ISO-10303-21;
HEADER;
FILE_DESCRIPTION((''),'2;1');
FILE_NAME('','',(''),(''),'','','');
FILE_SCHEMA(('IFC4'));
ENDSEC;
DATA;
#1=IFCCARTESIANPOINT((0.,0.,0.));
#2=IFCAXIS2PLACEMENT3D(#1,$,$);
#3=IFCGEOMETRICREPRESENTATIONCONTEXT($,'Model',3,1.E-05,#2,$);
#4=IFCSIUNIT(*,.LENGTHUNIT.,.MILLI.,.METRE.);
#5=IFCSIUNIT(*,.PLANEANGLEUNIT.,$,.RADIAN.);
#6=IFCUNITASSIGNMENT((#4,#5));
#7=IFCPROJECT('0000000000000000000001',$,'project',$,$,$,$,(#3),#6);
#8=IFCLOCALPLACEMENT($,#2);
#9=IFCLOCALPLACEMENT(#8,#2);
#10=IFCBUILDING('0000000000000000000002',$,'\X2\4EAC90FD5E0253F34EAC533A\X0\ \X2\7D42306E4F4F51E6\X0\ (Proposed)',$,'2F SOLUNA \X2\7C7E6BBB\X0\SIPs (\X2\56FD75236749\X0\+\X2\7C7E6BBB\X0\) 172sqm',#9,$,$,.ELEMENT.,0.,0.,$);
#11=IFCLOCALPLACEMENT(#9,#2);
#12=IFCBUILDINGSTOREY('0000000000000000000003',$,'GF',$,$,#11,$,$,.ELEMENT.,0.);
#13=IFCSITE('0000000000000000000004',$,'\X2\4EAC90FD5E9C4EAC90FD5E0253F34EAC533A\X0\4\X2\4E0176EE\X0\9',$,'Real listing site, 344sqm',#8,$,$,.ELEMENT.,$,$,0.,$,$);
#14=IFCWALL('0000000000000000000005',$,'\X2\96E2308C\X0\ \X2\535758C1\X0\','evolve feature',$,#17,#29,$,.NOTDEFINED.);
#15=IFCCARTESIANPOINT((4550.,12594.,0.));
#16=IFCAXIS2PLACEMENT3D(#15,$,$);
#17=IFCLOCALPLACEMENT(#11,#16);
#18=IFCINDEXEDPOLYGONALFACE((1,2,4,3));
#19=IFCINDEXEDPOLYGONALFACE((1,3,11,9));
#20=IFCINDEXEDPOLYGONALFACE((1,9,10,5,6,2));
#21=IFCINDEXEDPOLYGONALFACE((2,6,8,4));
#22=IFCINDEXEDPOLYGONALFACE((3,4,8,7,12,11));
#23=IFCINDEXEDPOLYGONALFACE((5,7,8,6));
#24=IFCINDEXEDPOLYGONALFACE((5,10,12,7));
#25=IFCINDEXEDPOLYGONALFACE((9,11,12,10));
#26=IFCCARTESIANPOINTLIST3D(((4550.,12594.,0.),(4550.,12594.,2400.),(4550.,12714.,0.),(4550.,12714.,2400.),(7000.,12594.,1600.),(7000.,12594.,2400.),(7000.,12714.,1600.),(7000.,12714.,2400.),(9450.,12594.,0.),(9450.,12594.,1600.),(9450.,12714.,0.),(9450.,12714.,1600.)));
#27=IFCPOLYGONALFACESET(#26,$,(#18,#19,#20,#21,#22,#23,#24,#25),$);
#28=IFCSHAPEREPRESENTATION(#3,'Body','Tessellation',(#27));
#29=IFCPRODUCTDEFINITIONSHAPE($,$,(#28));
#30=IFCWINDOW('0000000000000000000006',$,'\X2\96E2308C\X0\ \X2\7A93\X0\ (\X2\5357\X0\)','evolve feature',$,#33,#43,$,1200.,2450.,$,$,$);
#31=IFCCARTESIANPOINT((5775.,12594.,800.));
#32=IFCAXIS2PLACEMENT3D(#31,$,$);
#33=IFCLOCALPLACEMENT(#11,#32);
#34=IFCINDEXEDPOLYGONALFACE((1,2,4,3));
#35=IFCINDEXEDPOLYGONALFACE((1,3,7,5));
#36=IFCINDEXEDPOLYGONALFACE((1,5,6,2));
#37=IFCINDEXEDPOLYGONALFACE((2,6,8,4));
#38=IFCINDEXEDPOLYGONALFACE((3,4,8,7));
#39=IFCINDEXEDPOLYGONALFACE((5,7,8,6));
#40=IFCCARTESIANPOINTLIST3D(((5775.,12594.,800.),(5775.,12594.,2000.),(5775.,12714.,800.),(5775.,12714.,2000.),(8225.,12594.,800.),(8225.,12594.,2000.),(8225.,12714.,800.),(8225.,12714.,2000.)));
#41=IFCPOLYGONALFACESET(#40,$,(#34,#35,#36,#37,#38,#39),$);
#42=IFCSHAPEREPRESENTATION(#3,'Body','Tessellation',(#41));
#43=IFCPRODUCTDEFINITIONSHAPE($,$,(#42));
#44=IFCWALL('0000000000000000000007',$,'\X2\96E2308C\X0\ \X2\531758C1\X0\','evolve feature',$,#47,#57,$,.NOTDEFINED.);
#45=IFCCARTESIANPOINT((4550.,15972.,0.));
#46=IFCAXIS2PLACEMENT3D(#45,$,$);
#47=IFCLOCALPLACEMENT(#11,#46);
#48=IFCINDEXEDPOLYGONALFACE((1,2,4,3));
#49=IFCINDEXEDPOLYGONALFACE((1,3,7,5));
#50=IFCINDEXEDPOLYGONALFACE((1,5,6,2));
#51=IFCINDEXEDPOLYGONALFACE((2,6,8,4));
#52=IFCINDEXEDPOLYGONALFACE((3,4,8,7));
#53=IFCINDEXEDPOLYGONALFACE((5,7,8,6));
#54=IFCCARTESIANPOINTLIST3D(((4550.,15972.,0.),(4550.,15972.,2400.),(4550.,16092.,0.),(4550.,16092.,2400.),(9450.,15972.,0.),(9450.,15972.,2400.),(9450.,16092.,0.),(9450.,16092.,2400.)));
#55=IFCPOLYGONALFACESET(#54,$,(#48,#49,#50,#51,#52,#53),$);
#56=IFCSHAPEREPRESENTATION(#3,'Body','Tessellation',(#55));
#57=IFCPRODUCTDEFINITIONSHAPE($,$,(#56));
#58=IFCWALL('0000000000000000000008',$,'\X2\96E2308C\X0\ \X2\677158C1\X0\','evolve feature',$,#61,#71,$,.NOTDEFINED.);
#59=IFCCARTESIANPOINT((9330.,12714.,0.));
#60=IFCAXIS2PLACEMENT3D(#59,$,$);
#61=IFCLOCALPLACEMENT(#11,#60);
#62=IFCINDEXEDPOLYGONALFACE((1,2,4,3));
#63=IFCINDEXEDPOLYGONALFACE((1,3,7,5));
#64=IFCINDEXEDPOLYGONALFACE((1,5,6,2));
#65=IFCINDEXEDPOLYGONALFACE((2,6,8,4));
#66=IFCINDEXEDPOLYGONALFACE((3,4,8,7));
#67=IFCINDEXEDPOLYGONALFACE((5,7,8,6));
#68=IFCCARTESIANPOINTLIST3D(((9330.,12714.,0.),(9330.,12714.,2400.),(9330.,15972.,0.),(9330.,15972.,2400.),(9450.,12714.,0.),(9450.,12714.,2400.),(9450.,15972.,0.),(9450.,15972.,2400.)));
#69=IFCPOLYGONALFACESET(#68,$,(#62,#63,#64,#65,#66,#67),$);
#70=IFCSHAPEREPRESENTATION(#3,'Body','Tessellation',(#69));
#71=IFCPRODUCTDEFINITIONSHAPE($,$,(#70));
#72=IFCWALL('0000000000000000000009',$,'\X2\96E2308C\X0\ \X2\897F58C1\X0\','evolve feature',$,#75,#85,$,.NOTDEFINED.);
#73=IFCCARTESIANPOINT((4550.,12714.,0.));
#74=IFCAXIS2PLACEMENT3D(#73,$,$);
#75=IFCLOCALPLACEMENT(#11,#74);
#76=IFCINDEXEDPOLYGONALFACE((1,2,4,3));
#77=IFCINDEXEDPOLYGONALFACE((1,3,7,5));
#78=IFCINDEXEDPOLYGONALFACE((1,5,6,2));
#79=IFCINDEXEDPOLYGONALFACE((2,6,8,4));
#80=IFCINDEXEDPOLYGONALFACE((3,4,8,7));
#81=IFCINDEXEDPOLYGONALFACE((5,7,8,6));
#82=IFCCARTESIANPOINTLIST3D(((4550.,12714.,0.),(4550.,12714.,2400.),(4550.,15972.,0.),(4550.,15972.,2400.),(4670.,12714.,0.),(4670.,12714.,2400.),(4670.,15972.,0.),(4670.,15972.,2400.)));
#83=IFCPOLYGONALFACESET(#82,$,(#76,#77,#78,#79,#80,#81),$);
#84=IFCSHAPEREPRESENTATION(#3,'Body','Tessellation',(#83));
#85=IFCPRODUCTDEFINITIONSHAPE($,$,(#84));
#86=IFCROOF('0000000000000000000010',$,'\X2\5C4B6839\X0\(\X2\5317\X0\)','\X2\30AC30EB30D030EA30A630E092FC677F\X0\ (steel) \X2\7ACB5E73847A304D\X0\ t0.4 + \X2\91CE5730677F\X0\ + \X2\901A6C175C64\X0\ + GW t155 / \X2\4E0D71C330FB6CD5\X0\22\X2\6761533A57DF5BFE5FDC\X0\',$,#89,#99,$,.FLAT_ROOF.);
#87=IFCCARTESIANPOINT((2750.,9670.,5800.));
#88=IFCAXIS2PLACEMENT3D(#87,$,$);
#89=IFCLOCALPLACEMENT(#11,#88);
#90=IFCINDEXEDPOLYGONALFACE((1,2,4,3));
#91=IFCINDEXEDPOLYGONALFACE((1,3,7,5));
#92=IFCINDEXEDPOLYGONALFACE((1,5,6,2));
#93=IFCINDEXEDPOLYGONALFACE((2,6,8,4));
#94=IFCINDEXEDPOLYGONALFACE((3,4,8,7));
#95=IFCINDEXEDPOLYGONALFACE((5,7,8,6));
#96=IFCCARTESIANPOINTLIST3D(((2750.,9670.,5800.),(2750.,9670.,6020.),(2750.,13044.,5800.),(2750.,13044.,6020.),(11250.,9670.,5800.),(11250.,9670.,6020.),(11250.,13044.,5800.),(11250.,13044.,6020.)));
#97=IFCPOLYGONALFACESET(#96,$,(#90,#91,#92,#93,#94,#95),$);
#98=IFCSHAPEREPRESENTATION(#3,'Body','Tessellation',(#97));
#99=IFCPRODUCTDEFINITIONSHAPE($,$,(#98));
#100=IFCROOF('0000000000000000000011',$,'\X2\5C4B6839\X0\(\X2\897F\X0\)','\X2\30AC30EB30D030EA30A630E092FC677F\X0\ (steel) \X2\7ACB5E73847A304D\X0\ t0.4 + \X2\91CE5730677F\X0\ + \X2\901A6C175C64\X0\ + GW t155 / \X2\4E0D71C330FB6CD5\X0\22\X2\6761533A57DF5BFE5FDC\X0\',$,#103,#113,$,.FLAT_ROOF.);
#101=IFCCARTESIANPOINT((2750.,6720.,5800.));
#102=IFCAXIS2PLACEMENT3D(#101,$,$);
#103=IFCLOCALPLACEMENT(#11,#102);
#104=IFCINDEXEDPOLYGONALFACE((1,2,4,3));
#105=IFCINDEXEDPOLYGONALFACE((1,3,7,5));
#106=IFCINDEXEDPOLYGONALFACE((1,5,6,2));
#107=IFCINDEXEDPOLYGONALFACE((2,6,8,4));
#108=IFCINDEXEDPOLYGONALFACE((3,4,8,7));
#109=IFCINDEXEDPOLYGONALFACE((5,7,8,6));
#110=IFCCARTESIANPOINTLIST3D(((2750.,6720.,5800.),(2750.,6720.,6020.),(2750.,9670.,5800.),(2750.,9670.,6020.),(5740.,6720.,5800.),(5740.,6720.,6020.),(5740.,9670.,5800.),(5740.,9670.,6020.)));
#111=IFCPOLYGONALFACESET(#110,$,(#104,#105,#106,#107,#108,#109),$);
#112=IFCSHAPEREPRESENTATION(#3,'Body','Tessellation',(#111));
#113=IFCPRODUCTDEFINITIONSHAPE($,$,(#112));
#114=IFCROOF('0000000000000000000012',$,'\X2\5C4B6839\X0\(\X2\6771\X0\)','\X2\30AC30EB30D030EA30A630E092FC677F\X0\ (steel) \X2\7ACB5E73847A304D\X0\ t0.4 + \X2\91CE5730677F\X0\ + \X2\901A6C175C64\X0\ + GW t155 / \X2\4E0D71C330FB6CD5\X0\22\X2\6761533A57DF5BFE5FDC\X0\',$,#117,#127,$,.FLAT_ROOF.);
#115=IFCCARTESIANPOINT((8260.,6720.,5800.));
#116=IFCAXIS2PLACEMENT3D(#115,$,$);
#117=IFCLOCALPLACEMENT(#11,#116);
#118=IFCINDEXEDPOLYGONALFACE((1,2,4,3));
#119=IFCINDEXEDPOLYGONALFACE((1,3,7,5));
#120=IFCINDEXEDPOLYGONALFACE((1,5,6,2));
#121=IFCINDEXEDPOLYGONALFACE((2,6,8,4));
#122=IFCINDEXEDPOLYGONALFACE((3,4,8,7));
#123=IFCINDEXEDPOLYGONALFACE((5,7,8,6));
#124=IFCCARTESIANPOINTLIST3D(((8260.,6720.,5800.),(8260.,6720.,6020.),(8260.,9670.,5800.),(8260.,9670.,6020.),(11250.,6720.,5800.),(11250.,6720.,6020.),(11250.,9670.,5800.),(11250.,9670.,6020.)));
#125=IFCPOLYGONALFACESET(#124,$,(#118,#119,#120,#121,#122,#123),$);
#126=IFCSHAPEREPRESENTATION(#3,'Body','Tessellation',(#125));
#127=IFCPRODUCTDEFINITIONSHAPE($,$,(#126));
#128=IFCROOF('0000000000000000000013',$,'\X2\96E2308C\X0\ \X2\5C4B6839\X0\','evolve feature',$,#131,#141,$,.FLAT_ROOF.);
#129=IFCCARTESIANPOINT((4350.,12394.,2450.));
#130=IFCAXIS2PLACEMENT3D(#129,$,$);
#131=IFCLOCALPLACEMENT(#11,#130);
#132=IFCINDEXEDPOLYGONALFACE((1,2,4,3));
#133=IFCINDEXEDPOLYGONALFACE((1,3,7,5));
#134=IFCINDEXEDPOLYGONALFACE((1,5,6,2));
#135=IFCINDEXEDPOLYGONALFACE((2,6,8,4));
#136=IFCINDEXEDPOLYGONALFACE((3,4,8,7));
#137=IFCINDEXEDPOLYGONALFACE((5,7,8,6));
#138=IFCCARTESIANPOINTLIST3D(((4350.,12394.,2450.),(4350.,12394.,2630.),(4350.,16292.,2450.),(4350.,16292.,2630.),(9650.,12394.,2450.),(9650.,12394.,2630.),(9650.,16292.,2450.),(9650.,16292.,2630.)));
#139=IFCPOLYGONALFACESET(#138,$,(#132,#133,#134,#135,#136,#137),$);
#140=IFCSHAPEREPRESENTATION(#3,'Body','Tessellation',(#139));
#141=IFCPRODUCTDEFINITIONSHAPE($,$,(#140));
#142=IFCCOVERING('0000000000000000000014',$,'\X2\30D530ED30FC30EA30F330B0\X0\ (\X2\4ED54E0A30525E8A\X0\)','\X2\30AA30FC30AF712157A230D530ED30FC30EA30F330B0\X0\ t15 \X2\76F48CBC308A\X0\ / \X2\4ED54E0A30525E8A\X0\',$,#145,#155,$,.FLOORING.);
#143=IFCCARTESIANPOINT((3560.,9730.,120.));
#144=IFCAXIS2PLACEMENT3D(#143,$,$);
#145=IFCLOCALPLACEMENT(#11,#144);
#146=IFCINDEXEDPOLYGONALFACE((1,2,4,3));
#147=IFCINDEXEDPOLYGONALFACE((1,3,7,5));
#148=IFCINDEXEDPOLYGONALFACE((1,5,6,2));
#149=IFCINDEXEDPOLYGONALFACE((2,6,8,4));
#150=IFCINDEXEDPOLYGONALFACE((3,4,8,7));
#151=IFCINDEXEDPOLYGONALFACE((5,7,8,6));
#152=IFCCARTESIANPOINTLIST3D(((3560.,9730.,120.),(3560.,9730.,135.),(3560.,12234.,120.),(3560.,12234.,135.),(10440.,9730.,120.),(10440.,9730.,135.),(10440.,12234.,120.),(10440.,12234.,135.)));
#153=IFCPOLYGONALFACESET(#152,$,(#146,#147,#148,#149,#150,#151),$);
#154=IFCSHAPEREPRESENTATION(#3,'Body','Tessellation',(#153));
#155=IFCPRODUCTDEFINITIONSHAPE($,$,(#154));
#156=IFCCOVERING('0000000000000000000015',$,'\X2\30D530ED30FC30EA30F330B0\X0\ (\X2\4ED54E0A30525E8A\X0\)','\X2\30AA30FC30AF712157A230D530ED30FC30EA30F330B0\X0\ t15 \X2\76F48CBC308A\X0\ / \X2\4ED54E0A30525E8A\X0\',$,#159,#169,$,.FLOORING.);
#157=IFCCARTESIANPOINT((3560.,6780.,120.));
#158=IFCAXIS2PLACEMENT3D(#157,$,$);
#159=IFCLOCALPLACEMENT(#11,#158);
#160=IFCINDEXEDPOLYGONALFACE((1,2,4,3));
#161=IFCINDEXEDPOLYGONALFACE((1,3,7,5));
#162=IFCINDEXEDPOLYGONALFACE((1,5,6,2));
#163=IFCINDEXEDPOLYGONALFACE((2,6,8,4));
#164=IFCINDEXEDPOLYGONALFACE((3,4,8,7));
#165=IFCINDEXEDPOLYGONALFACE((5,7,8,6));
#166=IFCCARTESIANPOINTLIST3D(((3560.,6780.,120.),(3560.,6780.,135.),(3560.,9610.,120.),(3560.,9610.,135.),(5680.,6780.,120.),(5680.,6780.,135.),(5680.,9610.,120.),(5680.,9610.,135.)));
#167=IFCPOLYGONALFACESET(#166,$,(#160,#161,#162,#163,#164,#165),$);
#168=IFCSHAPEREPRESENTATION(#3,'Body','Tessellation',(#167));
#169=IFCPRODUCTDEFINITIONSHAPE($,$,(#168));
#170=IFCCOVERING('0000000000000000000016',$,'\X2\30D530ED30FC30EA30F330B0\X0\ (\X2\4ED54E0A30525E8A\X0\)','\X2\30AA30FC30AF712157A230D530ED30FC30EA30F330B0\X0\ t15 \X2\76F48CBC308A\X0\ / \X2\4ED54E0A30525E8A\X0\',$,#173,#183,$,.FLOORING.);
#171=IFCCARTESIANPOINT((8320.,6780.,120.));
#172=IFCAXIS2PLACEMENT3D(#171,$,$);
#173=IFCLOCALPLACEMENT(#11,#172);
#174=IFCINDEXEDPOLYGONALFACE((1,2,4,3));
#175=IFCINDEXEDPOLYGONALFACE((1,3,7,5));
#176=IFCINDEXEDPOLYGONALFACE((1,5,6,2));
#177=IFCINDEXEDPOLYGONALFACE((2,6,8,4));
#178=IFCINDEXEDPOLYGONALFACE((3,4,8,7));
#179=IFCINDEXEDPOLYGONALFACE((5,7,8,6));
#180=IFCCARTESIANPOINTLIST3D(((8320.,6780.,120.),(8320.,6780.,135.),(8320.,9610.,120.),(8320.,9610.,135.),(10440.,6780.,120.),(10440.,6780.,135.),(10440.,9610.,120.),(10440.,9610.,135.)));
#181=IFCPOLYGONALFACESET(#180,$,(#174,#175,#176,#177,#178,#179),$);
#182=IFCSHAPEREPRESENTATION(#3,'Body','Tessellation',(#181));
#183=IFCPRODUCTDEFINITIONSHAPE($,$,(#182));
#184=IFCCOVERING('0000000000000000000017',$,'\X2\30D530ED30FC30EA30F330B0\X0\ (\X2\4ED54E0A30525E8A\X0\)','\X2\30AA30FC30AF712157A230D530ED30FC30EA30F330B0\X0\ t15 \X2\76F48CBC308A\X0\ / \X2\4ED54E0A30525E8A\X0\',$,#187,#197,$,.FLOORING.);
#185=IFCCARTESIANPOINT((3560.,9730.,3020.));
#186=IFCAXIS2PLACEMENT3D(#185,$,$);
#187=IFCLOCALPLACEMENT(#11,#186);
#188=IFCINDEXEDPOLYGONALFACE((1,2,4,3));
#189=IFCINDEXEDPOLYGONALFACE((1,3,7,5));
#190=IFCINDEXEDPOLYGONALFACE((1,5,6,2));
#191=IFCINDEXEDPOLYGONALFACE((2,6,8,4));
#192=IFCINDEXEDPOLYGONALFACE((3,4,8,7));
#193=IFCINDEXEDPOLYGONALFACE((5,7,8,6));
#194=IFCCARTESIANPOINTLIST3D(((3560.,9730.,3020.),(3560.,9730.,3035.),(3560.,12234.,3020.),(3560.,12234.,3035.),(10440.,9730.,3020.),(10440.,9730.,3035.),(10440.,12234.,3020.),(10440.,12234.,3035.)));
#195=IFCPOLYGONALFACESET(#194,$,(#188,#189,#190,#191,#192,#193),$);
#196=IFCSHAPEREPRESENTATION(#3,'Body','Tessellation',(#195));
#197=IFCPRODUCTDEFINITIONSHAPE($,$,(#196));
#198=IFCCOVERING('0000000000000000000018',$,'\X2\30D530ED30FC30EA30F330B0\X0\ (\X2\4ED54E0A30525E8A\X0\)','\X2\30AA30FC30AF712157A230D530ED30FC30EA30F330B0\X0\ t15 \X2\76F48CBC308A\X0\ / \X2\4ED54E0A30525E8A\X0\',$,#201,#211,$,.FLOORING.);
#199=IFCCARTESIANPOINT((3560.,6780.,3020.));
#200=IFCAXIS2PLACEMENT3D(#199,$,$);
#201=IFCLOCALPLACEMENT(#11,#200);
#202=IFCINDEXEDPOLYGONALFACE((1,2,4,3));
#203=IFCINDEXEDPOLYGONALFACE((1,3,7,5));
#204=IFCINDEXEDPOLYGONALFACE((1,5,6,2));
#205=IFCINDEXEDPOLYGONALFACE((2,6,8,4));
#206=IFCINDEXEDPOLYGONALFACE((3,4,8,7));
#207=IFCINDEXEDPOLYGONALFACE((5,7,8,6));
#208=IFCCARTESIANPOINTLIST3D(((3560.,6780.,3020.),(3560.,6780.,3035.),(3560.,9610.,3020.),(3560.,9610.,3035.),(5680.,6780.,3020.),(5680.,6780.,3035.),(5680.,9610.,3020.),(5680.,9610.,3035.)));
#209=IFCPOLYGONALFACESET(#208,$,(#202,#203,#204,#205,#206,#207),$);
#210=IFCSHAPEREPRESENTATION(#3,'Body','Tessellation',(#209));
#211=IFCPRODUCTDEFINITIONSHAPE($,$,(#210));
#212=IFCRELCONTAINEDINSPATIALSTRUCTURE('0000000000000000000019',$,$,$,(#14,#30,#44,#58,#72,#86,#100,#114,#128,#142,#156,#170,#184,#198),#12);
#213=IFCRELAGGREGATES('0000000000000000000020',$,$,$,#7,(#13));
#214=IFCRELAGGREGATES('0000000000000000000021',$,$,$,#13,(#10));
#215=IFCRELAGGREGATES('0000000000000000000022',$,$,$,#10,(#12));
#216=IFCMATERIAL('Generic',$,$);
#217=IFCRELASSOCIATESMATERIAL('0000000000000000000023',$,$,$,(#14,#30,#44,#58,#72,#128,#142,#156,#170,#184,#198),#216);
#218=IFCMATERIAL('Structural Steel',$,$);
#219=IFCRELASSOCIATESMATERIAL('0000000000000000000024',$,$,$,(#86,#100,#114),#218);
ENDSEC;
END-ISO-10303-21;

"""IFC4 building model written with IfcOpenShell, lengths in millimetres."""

from ifc_helpers import new_model, si_unit, frame, frame_2d, origin, place, context, project, spatial, rectangle, extrude, material, element, fill, save


model = new_model("IFC4")

# Units and contexts
model_context = context("Model", 3, precision=1e-05, world=origin())
ifc_project = project(units=[si_unit("LENGTHUNIT", "METRE", prefix="MILLI"), si_unit("PLANEANGLEUNIT", "RADIAN")], contexts=[model_context])

# Site, building, storey
site_placement = place(None, origin())
site = spatial("IfcSite", under=ifc_project, at=site_placement, Name="京都府京都市右京区4丁目9", ObjectType="Real listing site, 344sqm", CompositionType="ELEMENT", RefElevation=0.0)
building_placement = place(site_placement, origin())
building = spatial("IfcBuilding", under=site, at=building_placement, Name="京都市右京区 終の住処 (Proposed)", ObjectType="2F SOLUNA 籾殻SIPs (国産杉+籾殻) 172sqm", CompositionType="ELEMENT", ElevationOfRefHeight=0.0, ElevationOfTerrain=0.0)
storey_placement = place(building_placement, origin())
storey = spatial("IfcBuildingStorey", under=building, at=storey_placement, Name="GF", CompositionType="ELEMENT", Elevation=0.0)

# Shared definitions
ifc_material_1 = material(Name="Generic")

# Wall, opening, window
wall_1_placement = place(storey_placement, frame((4550.0, 12594.0, 0.0)))
wall_1 = element("IfcWall", 1, at=wall_1_placement, inside=storey, material=ifc_material_1, Name="離れ 南壁", Description="evolve feature", PredefinedType="NOTDEFINED", context=model_context, shape_type="SweptSolid", body=[
    extrude(rectangle(XDim=4900.0, YDim=120.0, at=frame_2d((2450.0, 60.0))), frame((4550.0, 12594.0, 0.0)), (0.0, 0.0, 1.0), 2400.0),
])
opening_1_placement = place(storey_placement, frame((5775.0, 12594.0, 800.0)))
opening_1 = element("IfcOpeningElement", 2, at=opening_1_placement, cuts=wall_1, PredefinedType="NOTDEFINED", context=model_context, shape_type="SweptSolid", body=[
    extrude(rectangle(XDim=2450.0, YDim=120.0, at=frame_2d((1225.0, 60.0))), frame((5775.0, 12594.0, 800.0)), (0.0, 0.0, 1.0), 1200.0),
])
window_1_placement = place(storey_placement, frame((5775.0, 12594.0, 800.0)))
window_1 = element("IfcWindow", 3, at=window_1_placement, inside=storey, material=ifc_material_1, Name="離れ 窓 (南)", Description="evolve feature", OverallHeight=1200.0, OverallWidth=2450.0, context=model_context, shape_type="SweptSolid", body=[
    extrude(rectangle(XDim=2450.0, YDim=120.0, at=frame_2d((1225.0, 60.0))), frame((5775.0, 12594.0, 800.0)), (0.0, 0.0, 1.0), 1200.0),
])
fill(opening_1, window_1)

# Walls
wall_2_placement = place(storey_placement, frame((4550.0, 15972.0, 0.0)))
element("IfcWall", 4, at=wall_2_placement, inside=storey, material=ifc_material_1, Name="離れ 北壁", Description="evolve feature", PredefinedType="NOTDEFINED", context=model_context, shape_type="SweptSolid", body=[
    extrude(rectangle(XDim=4900.0, YDim=120.0, at=frame_2d((2450.0, 60.0))), frame((4550.0, 15972.0, 0.0)), (0.0, 0.0, 1.0), 2400.0),
])
wall_3_placement = place(storey_placement, frame((9330.0, 12714.0, 0.0)))
element("IfcWall", 5, at=wall_3_placement, inside=storey, material=ifc_material_1, Name="離れ 東壁", Description="evolve feature", PredefinedType="NOTDEFINED", context=model_context, shape_type="SweptSolid", body=[
    extrude(rectangle(XDim=120.0, YDim=3258.0, at=frame_2d((60.0, 1629.0))), frame((9330.0, 12714.0, 0.0)), (0.0, 0.0, 1.0), 2400.0),
])
wall_4_placement = place(storey_placement, frame((4550.0, 12714.0, 0.0)))
element("IfcWall", 6, at=wall_4_placement, inside=storey, material=ifc_material_1, Name="離れ 西壁", Description="evolve feature", PredefinedType="NOTDEFINED", context=model_context, shape_type="SweptSolid", body=[
    extrude(rectangle(XDim=120.0, YDim=3258.0, at=frame_2d((60.0, 1629.0))), frame((4550.0, 12714.0, 0.0)), (0.0, 0.0, 1.0), 2400.0),
])

# Roofs
ifc_material_2 = material(Name="Structural Steel")
for number, where, name in (
    (7, (2750.0, 9670.0, 5800.0), "屋根(北)"),
):
    element("IfcRoof", number, at=place(storey_placement, frame(where)), inside=storey, material=ifc_material_2, Name=name, Description="ガルバリウム鋼板 (steel) 立平葺き t0.4 + 野地板 + 通気層 + GW t155 / 不燃・法22条区域対応", PredefinedType="FLAT_ROOF", context=model_context, shape_type="SweptSolid", body=[
        extrude(rectangle(XDim=8500.0, YDim=3374.0, at=frame_2d((4250.0, 1687.0))), frame((2750.0, 9670.0, 5800.0)), (0.0, 0.0, 1.0), 220.0),
    ])
roof_1_placement = place(storey_placement, frame((2750.0, 6720.0, 5800.0)))
element("IfcRoof", 8, at=roof_1_placement, inside=storey, material=ifc_material_2, Name="屋根(西)", Description="ガルバリウム鋼板 (steel) 立平葺き t0.4 + 野地板 + 通気層 + GW t155 / 不燃・法22条区域対応", PredefinedType="FLAT_ROOF", context=model_context, shape_type="SweptSolid", body=[
    extrude(rectangle(XDim=2990.0, YDim=2950.0, at=frame_2d((1495.0, 1475.0))), frame((2750.0, 6720.0, 5800.0)), (0.0, 0.0, 1.0), 220.0),
])
roof_2_placement = place(storey_placement, frame((8260.0, 6720.0, 5800.0)))
element("IfcRoof", 9, at=roof_2_placement, inside=storey, material=ifc_material_2, Name="屋根(東)", Description="ガルバリウム鋼板 (steel) 立平葺き t0.4 + 野地板 + 通気層 + GW t155 / 不燃・法22条区域対応", PredefinedType="FLAT_ROOF", context=model_context, shape_type="SweptSolid", body=[
    extrude(rectangle(XDim=2990.0, YDim=2950.0, at=frame_2d((1495.0, 1475.0))), frame((8260.0, 6720.0, 5800.0)), (0.0, 0.0, 1.0), 220.0),
])
roof_3_placement = place(storey_placement, frame((4350.0, 12394.0, 2450.0)))
element("IfcRoof", 10, at=roof_3_placement, inside=storey, material=ifc_material_1, Name="離れ 屋根", Description="evolve feature", PredefinedType="FLAT_ROOF", context=model_context, shape_type="SweptSolid", body=[
    extrude(rectangle(XDim=5300.0, YDim=3898.0, at=frame_2d((2650.0, 1949.0))), frame((4350.0, 12394.0, 2450.0)), (0.0, 0.0, 1.0), 180.0),
])

# Coverings
covering_1_placement = place(storey_placement, frame((3560.0, 9730.0, 120.0)))
element("IfcCovering", 11, at=covering_1_placement, inside=storey, material=ifc_material_1, Name="フローリング (仕上げ床)", Description="オーク無垢フローリング t15 直貼り / 仕上げ床", PredefinedType="FLOORING", context=model_context, shape_type="SweptSolid", body=[
    extrude(rectangle(XDim=6880.0, YDim=2504.0, at=frame_2d((3440.0, 1252.0))), frame((3560.0, 9730.0, 120.0)), (0.0, 0.0, 1.0), 15.0),
])
covering_2_placement = place(storey_placement, frame((3560.0, 6780.0, 120.0)))
element("IfcCovering", 12, at=covering_2_placement, inside=storey, material=ifc_material_1, Name="フローリング (仕上げ床)", Description="オーク無垢フローリング t15 直貼り / 仕上げ床", PredefinedType="FLOORING", context=model_context, shape_type="SweptSolid", body=[
    extrude(rectangle(XDim=2120.0, YDim=2830.0, at=frame_2d((1060.0, 1415.0))), frame((3560.0, 6780.0, 120.0)), (0.0, 0.0, 1.0), 15.0),
])
covering_3_placement = place(storey_placement, frame((8320.0, 6780.0, 120.0)))
element("IfcCovering", 13, at=covering_3_placement, inside=storey, material=ifc_material_1, Name="フローリング (仕上げ床)", Description="オーク無垢フローリング t15 直貼り / 仕上げ床", PredefinedType="FLOORING", context=model_context, shape_type="SweptSolid", body=[
    extrude(rectangle(XDim=2120.0, YDim=2830.0, at=frame_2d((1060.0, 1415.0))), frame((8320.0, 6780.0, 120.0)), (0.0, 0.0, 1.0), 15.0),
])
covering_4_placement = place(storey_placement, frame((3560.0, 9730.0, 3020.0)))
element("IfcCovering", 14, at=covering_4_placement, inside=storey, material=ifc_material_1, Name="フローリング (仕上げ床)", Description="オーク無垢フローリング t15 直貼り / 仕上げ床", PredefinedType="FLOORING", context=model_context, shape_type="SweptSolid", body=[
    extrude(rectangle(XDim=6880.0, YDim=2504.0, at=frame_2d((3440.0, 1252.0))), frame((3560.0, 9730.0, 3020.0)), (0.0, 0.0, 1.0), 15.0),
])
covering_5_placement = place(storey_placement, frame((3560.0, 6780.0, 3020.0)))
element("IfcCovering", 15, at=covering_5_placement, inside=storey, material=ifc_material_1, Name="フローリング (仕上げ床)", Description="オーク無垢フローリング t15 直貼り / 仕上げ床", PredefinedType="FLOORING", context=model_context, shape_type="SweptSolid", body=[
    extrude(rectangle(XDim=2120.0, YDim=2830.0, at=frame_2d((1060.0, 1415.0))), frame((3560.0, 6780.0, 3020.0)), (0.0, 0.0, 1.0), 15.0),
])

save(model, "model.ifc")
